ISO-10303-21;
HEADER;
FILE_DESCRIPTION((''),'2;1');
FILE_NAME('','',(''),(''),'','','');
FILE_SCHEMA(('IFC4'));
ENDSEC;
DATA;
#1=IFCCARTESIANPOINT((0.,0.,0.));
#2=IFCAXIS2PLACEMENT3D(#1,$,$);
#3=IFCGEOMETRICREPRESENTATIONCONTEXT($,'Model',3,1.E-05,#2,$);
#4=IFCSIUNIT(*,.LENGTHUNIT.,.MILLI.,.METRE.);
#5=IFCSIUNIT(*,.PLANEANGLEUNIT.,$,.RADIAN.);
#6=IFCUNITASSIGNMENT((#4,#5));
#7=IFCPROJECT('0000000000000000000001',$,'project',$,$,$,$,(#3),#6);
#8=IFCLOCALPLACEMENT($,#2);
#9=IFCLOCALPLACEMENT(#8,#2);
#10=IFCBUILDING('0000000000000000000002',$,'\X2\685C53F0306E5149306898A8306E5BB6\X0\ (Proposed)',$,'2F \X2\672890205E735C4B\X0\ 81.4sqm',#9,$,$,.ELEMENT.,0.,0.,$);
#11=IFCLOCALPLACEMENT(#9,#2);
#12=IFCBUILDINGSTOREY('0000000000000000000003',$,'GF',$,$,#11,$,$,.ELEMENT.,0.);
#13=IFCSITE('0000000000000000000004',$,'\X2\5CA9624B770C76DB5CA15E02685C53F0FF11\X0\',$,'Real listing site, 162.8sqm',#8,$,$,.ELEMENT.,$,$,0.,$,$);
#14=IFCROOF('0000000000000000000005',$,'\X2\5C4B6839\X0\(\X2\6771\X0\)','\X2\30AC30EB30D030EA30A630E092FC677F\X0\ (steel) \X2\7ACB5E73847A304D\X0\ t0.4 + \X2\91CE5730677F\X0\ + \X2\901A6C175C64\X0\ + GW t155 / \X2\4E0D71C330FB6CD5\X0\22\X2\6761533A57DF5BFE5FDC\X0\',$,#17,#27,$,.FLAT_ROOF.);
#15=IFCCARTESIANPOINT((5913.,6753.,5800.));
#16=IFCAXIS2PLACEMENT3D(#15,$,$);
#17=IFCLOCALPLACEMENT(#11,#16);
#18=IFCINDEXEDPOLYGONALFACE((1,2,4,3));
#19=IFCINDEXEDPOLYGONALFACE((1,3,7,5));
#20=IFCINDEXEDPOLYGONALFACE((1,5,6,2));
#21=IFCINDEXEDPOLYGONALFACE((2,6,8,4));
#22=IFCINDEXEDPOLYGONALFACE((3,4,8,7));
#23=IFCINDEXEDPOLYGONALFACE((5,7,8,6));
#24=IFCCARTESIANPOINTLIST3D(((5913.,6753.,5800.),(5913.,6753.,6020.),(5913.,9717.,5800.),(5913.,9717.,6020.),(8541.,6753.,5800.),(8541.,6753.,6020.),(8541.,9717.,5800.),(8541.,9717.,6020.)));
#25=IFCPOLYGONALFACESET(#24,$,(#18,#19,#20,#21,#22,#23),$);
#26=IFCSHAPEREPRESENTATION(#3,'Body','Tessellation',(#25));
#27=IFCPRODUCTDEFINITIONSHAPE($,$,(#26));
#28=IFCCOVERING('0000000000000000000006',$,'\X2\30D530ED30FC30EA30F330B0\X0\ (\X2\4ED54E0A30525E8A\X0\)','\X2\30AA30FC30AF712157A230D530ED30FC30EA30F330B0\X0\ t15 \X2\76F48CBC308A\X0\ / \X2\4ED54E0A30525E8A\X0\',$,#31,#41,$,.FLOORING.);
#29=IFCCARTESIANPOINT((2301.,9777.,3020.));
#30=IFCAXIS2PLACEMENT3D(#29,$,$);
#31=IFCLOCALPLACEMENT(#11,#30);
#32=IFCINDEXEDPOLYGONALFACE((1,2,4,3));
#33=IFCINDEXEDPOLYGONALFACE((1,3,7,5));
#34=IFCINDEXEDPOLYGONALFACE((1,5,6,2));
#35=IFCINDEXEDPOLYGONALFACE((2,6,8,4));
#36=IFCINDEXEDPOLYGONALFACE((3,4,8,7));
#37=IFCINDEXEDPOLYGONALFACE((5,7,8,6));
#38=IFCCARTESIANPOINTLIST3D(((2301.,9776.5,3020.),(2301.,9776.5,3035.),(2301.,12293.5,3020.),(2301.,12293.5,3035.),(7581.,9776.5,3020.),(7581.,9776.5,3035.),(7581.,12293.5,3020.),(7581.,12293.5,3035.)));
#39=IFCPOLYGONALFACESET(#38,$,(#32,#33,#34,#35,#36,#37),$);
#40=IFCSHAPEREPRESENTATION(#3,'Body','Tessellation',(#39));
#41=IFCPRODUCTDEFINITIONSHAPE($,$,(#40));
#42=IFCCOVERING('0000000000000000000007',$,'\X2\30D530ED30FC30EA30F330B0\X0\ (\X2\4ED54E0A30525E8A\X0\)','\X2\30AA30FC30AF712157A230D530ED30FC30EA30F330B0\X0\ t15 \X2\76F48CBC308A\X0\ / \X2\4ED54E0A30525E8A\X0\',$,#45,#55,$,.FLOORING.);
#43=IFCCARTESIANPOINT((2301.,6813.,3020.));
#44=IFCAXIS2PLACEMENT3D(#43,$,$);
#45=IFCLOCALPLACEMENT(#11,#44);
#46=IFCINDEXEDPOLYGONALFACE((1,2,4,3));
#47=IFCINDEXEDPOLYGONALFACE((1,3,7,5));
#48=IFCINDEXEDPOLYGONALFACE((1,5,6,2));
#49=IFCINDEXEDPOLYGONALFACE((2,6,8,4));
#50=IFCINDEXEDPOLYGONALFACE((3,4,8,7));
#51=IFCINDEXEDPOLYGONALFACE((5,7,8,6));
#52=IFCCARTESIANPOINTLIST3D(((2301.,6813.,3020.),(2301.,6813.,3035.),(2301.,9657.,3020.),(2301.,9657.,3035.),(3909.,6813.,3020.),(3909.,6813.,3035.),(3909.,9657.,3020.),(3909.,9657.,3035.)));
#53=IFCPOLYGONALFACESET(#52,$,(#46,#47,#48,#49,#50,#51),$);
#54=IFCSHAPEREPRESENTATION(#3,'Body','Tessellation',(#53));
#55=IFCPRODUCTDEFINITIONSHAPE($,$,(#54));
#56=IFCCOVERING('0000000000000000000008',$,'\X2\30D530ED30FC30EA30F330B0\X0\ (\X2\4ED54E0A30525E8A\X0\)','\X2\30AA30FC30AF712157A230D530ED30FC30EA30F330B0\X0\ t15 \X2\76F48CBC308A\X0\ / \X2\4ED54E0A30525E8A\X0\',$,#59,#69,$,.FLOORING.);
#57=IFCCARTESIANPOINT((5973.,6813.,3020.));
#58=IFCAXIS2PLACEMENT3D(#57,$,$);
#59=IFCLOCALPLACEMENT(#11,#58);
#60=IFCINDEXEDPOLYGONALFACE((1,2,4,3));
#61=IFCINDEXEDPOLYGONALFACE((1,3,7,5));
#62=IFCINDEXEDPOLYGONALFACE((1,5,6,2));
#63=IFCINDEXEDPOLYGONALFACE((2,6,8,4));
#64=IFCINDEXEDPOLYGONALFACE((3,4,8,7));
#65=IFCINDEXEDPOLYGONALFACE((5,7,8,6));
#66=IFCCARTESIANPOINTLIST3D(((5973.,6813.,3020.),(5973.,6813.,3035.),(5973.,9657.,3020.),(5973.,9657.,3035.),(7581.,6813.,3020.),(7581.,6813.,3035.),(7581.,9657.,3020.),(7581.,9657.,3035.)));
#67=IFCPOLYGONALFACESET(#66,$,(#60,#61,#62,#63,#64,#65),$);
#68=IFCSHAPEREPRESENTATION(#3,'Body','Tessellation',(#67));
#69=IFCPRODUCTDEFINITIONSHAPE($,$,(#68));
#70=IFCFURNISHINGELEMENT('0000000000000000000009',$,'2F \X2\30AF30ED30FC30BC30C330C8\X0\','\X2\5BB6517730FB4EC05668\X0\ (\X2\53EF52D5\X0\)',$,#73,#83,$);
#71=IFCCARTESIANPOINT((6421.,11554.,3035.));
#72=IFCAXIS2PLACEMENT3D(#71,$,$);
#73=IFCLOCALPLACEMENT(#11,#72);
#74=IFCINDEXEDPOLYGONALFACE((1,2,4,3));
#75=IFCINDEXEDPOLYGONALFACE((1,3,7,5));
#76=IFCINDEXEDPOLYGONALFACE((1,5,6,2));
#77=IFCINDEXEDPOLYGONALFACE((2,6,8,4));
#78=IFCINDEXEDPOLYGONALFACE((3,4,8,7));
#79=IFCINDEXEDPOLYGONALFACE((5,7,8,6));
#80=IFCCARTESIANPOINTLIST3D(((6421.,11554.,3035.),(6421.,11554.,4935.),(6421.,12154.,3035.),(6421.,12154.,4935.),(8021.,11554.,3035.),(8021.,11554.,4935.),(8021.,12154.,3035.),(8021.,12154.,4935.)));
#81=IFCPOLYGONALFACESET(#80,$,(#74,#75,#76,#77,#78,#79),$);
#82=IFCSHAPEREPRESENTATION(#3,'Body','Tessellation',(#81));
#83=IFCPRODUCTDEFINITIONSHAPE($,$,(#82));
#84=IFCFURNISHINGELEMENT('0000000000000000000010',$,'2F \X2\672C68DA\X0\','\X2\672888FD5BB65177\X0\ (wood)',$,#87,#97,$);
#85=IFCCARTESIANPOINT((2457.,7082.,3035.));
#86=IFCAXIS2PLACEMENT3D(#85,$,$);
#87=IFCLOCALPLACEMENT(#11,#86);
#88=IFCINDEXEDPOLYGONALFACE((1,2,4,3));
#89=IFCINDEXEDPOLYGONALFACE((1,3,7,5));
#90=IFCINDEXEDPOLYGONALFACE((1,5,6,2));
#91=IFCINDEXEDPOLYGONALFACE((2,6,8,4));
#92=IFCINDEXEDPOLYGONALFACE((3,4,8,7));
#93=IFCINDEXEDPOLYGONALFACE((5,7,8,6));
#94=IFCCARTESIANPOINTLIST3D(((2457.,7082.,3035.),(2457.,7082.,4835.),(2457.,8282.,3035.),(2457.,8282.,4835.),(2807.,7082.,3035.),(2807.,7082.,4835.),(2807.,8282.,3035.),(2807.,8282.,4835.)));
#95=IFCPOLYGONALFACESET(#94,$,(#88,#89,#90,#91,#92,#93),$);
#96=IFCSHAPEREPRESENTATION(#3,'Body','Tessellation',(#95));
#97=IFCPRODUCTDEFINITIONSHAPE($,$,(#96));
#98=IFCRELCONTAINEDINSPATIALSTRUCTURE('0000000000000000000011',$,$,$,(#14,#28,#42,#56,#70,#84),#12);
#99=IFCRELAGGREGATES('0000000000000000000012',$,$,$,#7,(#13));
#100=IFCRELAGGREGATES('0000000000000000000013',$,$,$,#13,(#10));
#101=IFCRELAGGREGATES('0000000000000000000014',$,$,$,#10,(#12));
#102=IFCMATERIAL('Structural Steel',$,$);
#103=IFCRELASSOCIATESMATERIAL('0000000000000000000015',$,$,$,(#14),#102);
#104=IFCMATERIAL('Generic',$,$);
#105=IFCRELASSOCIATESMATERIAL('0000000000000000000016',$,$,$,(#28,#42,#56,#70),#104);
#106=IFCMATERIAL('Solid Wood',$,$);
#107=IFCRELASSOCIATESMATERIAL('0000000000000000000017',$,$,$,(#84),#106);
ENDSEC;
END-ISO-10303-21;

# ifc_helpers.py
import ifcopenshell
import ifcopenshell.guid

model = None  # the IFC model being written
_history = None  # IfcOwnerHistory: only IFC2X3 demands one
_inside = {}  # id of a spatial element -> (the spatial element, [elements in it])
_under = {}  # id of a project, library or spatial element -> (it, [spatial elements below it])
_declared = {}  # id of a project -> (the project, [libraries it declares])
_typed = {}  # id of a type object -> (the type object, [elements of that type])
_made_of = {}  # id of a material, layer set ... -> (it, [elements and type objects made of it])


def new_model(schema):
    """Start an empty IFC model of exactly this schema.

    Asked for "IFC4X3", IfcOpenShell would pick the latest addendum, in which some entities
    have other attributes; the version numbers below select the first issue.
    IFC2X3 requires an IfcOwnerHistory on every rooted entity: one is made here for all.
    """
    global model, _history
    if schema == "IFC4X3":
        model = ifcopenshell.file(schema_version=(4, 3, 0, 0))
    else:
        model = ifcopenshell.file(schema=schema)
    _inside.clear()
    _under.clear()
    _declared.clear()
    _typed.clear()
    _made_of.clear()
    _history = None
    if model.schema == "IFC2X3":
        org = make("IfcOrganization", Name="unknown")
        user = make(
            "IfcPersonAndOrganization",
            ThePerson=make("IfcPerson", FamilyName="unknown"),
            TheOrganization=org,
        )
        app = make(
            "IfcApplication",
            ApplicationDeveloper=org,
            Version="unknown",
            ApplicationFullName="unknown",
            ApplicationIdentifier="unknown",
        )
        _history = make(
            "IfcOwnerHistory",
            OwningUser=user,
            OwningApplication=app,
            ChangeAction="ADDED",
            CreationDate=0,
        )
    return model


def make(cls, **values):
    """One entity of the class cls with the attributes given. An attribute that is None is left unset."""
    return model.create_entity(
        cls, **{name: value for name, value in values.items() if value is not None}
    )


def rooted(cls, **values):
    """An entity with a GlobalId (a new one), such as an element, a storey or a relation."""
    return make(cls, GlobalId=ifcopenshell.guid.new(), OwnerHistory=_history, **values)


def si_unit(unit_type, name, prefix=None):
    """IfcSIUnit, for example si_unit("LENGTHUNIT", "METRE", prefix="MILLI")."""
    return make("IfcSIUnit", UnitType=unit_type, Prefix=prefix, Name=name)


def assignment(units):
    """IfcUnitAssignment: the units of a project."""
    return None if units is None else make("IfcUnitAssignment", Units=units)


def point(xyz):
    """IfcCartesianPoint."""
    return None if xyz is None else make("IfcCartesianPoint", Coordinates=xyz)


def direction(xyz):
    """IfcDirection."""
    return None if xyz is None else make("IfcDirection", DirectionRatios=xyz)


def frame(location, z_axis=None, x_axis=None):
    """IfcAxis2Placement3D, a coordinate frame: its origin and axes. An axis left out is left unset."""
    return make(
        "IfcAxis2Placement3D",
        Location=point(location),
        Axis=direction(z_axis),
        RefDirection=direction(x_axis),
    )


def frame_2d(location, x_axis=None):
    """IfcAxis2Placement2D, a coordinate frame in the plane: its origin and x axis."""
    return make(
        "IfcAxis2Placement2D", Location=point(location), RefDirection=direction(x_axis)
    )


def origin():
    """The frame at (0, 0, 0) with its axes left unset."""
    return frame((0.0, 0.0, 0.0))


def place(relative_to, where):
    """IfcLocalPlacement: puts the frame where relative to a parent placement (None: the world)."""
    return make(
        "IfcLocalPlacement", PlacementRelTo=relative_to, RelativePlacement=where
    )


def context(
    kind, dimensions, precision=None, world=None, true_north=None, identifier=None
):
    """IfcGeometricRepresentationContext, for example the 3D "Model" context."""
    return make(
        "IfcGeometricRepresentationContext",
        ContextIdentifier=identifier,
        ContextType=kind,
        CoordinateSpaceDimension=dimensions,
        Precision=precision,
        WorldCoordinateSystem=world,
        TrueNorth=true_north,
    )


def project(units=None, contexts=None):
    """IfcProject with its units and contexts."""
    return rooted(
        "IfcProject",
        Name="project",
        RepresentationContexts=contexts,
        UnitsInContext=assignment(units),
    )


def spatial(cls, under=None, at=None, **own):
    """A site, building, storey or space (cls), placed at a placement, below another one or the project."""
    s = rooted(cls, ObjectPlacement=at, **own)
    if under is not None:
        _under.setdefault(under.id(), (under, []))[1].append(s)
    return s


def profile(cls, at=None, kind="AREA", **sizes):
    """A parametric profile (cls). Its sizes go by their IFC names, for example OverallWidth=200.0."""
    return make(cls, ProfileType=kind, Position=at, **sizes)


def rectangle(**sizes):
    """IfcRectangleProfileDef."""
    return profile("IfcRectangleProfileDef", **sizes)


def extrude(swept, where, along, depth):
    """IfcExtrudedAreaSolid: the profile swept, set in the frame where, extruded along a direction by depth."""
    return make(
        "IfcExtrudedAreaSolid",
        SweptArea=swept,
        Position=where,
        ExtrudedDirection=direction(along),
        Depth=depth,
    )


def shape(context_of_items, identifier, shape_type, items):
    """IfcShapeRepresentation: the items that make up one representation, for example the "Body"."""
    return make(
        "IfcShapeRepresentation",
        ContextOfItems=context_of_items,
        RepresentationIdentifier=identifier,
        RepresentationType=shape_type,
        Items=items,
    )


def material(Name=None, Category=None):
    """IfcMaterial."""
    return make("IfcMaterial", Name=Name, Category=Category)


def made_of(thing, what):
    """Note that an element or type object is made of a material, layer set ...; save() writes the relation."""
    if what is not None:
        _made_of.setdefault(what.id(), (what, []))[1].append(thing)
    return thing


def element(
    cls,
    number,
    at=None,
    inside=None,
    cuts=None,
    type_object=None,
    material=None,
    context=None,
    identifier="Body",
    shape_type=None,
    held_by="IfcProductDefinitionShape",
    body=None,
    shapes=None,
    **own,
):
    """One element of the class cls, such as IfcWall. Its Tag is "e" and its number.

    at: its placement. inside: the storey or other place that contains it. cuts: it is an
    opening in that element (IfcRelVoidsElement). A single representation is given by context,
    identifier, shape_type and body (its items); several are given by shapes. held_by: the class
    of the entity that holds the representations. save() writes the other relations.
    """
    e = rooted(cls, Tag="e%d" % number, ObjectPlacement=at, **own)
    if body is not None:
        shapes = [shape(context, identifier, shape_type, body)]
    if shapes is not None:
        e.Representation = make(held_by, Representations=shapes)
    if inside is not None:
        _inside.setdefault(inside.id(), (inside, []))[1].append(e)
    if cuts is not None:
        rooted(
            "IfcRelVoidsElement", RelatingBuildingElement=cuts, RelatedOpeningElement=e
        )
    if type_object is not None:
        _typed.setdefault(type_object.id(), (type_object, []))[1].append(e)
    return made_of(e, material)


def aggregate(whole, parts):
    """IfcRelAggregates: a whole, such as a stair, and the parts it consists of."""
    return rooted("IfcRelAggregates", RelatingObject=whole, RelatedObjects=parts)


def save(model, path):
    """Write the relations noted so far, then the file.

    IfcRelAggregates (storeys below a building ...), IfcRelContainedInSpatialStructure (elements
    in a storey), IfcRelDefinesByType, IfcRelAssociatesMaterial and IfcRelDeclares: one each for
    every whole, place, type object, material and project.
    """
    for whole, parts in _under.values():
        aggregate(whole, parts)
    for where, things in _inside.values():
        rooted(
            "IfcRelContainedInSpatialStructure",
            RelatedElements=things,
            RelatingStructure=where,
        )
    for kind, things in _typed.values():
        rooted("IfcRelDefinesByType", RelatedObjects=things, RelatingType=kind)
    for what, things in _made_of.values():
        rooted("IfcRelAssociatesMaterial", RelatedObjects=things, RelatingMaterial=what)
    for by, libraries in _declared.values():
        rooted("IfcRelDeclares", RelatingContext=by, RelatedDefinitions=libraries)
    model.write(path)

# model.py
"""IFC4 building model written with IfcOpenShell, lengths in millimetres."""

from ifc_helpers import new_model, si_unit, frame, frame_2d, origin, place, context, project, spatial, rectangle, extrude, material, element, save


model = new_model("IFC4")

# Units and contexts
model_context = context("Model", 3, precision=1e-05, world=origin())
ifc_project = project(units=[si_unit("LENGTHUNIT", "METRE", prefix="MILLI"), si_unit("PLANEANGLEUNIT", "RADIAN")], contexts=[model_context])

# Site, building, storey
site_placement = place(None, origin())
site = spatial("IfcSite", under=ifc_project, at=site_placement, Name="岩手県盛岡市桜台１", ObjectType="Real listing site, 162.8sqm", CompositionType="ELEMENT", RefElevation=0.0)
building_placement = place(site_placement, origin())
building = spatial("IfcBuilding", under=site, at=building_placement, Name="桜台の光と風の家 (Proposed)", ObjectType="2F 木造平屋 81.4sqm", CompositionType="ELEMENT", ElevationOfRefHeight=0.0, ElevationOfTerrain=0.0)
storey_placement = place(building_placement, origin())
storey = spatial("IfcBuildingStorey", under=building, at=storey_placement, Name="GF", CompositionType="ELEMENT", Elevation=0.0)

# Shared definitions
ifc_material_1 = material(Name="Solid Wood")

# Roof
ifc_material_2 = material(Name="Structural Steel")
roof_1_placement = place(storey_placement, frame((5913.0, 6753.0, 5800.0)))
element("IfcRoof", 1, at=roof_1_placement, inside=storey, material=ifc_material_2, Name="屋根(東)", Description="ガルバリウム鋼板 (steel) 立平葺き t0.4 + 野地板 + 通気層 + GW t155 / 不燃・法22条区域対応", PredefinedType="FLAT_ROOF", context=model_context, shape_type="SweptSolid", body=[
    extrude(rectangle(XDim=2628.0, YDim=2964.0, at=frame_2d((1314.0, 1482.0))), frame((5913.0, 6753.0, 5800.0)), (0.0, 0.0, 1.0), 220.0),
])

# Coverings
ifc_material_3 = material(Name="Generic")
covering_1_placement = place(storey_placement, frame((2301.0, 9777.0, 3020.0)))
element("IfcCovering", 2, at=covering_1_placement, inside=storey, material=ifc_material_3, Name="フローリング (仕上げ床)", Description="オーク無垢フローリング t15 直貼り / 仕上げ床", PredefinedType="FLOORING", context=model_context, shape_type="SweptSolid", body=[
    extrude(rectangle(XDim=5280.0, YDim=2517.0, at=frame_2d((2640.0, 1258.0))), frame((2301.0, 9777.0, 3020.0)), (0.0, 0.0, 1.0), 15.0),
])
covering_2_placement = place(storey_placement, frame((2301.0, 6813.0, 3020.0)))
element("IfcCovering", 3, at=covering_2_placement, inside=storey, material=ifc_material_3, Name="フローリング (仕上げ床)", Description="オーク無垢フローリング t15 直貼り / 仕上げ床", PredefinedType="FLOORING", context=model_context, shape_type="SweptSolid", body=[
    extrude(rectangle(XDim=1608.0, YDim=2844.0, at=frame_2d((804.0, 1422.0))), frame((2301.0, 6813.0, 3020.0)), (0.0, 0.0, 1.0), 15.0),
])
covering_3_placement = place(storey_placement, frame((5973.0, 6813.0, 3020.0)))
element("IfcCovering", 4, at=covering_3_placement, inside=storey, material=ifc_material_3, Name="フローリング (仕上げ床)", Description="オーク無垢フローリング t15 直貼り / 仕上げ床", PredefinedType="FLOORING", context=model_context, shape_type="SweptSolid", body=[
    extrude(rectangle(XDim=1608.0, YDim=2844.0, at=frame_2d((804.0, 1422.0))), frame((5973.0, 6813.0, 3020.0)), (0.0, 0.0, 1.0), 15.0),
])

# Furnishing elements
furnishing_1_placement = place(storey_placement, frame((6421.0, 11554.0, 3035.0)))
element("IfcFurnishingElement", 5, at=furnishing_1_placement, inside=storey, material=ifc_material_3, Name="2F クローゼット", Description="家具・什器 (可動)", context=model_context, shape_type="SweptSolid", body=[
    extrude(rectangle(XDim=1600.0, YDim=600.0, at=frame_2d((800.0, 300.0))), frame((6421.0, 11554.0, 3035.0)), (0.0, 0.0, 1.0), 1900.0),
])
furnishing_2_placement = place(storey_placement, frame((2457.0, 7082.0, 3035.0)))
element("IfcFurnishingElement", 6, at=furnishing_2_placement, inside=storey, material=ifc_material_1, Name="2F 本棚", Description="木製家具 (wood)", context=model_context, shape_type="SweptSolid", body=[
    extrude(rectangle(XDim=350.0, YDim=1200.0, at=frame_2d((175.0, 600.0))), frame((2457.0, 7082.0, 3035.0)), (0.0, 0.0, 1.0), 1800.0),
])

save(model, "model.ifc")
